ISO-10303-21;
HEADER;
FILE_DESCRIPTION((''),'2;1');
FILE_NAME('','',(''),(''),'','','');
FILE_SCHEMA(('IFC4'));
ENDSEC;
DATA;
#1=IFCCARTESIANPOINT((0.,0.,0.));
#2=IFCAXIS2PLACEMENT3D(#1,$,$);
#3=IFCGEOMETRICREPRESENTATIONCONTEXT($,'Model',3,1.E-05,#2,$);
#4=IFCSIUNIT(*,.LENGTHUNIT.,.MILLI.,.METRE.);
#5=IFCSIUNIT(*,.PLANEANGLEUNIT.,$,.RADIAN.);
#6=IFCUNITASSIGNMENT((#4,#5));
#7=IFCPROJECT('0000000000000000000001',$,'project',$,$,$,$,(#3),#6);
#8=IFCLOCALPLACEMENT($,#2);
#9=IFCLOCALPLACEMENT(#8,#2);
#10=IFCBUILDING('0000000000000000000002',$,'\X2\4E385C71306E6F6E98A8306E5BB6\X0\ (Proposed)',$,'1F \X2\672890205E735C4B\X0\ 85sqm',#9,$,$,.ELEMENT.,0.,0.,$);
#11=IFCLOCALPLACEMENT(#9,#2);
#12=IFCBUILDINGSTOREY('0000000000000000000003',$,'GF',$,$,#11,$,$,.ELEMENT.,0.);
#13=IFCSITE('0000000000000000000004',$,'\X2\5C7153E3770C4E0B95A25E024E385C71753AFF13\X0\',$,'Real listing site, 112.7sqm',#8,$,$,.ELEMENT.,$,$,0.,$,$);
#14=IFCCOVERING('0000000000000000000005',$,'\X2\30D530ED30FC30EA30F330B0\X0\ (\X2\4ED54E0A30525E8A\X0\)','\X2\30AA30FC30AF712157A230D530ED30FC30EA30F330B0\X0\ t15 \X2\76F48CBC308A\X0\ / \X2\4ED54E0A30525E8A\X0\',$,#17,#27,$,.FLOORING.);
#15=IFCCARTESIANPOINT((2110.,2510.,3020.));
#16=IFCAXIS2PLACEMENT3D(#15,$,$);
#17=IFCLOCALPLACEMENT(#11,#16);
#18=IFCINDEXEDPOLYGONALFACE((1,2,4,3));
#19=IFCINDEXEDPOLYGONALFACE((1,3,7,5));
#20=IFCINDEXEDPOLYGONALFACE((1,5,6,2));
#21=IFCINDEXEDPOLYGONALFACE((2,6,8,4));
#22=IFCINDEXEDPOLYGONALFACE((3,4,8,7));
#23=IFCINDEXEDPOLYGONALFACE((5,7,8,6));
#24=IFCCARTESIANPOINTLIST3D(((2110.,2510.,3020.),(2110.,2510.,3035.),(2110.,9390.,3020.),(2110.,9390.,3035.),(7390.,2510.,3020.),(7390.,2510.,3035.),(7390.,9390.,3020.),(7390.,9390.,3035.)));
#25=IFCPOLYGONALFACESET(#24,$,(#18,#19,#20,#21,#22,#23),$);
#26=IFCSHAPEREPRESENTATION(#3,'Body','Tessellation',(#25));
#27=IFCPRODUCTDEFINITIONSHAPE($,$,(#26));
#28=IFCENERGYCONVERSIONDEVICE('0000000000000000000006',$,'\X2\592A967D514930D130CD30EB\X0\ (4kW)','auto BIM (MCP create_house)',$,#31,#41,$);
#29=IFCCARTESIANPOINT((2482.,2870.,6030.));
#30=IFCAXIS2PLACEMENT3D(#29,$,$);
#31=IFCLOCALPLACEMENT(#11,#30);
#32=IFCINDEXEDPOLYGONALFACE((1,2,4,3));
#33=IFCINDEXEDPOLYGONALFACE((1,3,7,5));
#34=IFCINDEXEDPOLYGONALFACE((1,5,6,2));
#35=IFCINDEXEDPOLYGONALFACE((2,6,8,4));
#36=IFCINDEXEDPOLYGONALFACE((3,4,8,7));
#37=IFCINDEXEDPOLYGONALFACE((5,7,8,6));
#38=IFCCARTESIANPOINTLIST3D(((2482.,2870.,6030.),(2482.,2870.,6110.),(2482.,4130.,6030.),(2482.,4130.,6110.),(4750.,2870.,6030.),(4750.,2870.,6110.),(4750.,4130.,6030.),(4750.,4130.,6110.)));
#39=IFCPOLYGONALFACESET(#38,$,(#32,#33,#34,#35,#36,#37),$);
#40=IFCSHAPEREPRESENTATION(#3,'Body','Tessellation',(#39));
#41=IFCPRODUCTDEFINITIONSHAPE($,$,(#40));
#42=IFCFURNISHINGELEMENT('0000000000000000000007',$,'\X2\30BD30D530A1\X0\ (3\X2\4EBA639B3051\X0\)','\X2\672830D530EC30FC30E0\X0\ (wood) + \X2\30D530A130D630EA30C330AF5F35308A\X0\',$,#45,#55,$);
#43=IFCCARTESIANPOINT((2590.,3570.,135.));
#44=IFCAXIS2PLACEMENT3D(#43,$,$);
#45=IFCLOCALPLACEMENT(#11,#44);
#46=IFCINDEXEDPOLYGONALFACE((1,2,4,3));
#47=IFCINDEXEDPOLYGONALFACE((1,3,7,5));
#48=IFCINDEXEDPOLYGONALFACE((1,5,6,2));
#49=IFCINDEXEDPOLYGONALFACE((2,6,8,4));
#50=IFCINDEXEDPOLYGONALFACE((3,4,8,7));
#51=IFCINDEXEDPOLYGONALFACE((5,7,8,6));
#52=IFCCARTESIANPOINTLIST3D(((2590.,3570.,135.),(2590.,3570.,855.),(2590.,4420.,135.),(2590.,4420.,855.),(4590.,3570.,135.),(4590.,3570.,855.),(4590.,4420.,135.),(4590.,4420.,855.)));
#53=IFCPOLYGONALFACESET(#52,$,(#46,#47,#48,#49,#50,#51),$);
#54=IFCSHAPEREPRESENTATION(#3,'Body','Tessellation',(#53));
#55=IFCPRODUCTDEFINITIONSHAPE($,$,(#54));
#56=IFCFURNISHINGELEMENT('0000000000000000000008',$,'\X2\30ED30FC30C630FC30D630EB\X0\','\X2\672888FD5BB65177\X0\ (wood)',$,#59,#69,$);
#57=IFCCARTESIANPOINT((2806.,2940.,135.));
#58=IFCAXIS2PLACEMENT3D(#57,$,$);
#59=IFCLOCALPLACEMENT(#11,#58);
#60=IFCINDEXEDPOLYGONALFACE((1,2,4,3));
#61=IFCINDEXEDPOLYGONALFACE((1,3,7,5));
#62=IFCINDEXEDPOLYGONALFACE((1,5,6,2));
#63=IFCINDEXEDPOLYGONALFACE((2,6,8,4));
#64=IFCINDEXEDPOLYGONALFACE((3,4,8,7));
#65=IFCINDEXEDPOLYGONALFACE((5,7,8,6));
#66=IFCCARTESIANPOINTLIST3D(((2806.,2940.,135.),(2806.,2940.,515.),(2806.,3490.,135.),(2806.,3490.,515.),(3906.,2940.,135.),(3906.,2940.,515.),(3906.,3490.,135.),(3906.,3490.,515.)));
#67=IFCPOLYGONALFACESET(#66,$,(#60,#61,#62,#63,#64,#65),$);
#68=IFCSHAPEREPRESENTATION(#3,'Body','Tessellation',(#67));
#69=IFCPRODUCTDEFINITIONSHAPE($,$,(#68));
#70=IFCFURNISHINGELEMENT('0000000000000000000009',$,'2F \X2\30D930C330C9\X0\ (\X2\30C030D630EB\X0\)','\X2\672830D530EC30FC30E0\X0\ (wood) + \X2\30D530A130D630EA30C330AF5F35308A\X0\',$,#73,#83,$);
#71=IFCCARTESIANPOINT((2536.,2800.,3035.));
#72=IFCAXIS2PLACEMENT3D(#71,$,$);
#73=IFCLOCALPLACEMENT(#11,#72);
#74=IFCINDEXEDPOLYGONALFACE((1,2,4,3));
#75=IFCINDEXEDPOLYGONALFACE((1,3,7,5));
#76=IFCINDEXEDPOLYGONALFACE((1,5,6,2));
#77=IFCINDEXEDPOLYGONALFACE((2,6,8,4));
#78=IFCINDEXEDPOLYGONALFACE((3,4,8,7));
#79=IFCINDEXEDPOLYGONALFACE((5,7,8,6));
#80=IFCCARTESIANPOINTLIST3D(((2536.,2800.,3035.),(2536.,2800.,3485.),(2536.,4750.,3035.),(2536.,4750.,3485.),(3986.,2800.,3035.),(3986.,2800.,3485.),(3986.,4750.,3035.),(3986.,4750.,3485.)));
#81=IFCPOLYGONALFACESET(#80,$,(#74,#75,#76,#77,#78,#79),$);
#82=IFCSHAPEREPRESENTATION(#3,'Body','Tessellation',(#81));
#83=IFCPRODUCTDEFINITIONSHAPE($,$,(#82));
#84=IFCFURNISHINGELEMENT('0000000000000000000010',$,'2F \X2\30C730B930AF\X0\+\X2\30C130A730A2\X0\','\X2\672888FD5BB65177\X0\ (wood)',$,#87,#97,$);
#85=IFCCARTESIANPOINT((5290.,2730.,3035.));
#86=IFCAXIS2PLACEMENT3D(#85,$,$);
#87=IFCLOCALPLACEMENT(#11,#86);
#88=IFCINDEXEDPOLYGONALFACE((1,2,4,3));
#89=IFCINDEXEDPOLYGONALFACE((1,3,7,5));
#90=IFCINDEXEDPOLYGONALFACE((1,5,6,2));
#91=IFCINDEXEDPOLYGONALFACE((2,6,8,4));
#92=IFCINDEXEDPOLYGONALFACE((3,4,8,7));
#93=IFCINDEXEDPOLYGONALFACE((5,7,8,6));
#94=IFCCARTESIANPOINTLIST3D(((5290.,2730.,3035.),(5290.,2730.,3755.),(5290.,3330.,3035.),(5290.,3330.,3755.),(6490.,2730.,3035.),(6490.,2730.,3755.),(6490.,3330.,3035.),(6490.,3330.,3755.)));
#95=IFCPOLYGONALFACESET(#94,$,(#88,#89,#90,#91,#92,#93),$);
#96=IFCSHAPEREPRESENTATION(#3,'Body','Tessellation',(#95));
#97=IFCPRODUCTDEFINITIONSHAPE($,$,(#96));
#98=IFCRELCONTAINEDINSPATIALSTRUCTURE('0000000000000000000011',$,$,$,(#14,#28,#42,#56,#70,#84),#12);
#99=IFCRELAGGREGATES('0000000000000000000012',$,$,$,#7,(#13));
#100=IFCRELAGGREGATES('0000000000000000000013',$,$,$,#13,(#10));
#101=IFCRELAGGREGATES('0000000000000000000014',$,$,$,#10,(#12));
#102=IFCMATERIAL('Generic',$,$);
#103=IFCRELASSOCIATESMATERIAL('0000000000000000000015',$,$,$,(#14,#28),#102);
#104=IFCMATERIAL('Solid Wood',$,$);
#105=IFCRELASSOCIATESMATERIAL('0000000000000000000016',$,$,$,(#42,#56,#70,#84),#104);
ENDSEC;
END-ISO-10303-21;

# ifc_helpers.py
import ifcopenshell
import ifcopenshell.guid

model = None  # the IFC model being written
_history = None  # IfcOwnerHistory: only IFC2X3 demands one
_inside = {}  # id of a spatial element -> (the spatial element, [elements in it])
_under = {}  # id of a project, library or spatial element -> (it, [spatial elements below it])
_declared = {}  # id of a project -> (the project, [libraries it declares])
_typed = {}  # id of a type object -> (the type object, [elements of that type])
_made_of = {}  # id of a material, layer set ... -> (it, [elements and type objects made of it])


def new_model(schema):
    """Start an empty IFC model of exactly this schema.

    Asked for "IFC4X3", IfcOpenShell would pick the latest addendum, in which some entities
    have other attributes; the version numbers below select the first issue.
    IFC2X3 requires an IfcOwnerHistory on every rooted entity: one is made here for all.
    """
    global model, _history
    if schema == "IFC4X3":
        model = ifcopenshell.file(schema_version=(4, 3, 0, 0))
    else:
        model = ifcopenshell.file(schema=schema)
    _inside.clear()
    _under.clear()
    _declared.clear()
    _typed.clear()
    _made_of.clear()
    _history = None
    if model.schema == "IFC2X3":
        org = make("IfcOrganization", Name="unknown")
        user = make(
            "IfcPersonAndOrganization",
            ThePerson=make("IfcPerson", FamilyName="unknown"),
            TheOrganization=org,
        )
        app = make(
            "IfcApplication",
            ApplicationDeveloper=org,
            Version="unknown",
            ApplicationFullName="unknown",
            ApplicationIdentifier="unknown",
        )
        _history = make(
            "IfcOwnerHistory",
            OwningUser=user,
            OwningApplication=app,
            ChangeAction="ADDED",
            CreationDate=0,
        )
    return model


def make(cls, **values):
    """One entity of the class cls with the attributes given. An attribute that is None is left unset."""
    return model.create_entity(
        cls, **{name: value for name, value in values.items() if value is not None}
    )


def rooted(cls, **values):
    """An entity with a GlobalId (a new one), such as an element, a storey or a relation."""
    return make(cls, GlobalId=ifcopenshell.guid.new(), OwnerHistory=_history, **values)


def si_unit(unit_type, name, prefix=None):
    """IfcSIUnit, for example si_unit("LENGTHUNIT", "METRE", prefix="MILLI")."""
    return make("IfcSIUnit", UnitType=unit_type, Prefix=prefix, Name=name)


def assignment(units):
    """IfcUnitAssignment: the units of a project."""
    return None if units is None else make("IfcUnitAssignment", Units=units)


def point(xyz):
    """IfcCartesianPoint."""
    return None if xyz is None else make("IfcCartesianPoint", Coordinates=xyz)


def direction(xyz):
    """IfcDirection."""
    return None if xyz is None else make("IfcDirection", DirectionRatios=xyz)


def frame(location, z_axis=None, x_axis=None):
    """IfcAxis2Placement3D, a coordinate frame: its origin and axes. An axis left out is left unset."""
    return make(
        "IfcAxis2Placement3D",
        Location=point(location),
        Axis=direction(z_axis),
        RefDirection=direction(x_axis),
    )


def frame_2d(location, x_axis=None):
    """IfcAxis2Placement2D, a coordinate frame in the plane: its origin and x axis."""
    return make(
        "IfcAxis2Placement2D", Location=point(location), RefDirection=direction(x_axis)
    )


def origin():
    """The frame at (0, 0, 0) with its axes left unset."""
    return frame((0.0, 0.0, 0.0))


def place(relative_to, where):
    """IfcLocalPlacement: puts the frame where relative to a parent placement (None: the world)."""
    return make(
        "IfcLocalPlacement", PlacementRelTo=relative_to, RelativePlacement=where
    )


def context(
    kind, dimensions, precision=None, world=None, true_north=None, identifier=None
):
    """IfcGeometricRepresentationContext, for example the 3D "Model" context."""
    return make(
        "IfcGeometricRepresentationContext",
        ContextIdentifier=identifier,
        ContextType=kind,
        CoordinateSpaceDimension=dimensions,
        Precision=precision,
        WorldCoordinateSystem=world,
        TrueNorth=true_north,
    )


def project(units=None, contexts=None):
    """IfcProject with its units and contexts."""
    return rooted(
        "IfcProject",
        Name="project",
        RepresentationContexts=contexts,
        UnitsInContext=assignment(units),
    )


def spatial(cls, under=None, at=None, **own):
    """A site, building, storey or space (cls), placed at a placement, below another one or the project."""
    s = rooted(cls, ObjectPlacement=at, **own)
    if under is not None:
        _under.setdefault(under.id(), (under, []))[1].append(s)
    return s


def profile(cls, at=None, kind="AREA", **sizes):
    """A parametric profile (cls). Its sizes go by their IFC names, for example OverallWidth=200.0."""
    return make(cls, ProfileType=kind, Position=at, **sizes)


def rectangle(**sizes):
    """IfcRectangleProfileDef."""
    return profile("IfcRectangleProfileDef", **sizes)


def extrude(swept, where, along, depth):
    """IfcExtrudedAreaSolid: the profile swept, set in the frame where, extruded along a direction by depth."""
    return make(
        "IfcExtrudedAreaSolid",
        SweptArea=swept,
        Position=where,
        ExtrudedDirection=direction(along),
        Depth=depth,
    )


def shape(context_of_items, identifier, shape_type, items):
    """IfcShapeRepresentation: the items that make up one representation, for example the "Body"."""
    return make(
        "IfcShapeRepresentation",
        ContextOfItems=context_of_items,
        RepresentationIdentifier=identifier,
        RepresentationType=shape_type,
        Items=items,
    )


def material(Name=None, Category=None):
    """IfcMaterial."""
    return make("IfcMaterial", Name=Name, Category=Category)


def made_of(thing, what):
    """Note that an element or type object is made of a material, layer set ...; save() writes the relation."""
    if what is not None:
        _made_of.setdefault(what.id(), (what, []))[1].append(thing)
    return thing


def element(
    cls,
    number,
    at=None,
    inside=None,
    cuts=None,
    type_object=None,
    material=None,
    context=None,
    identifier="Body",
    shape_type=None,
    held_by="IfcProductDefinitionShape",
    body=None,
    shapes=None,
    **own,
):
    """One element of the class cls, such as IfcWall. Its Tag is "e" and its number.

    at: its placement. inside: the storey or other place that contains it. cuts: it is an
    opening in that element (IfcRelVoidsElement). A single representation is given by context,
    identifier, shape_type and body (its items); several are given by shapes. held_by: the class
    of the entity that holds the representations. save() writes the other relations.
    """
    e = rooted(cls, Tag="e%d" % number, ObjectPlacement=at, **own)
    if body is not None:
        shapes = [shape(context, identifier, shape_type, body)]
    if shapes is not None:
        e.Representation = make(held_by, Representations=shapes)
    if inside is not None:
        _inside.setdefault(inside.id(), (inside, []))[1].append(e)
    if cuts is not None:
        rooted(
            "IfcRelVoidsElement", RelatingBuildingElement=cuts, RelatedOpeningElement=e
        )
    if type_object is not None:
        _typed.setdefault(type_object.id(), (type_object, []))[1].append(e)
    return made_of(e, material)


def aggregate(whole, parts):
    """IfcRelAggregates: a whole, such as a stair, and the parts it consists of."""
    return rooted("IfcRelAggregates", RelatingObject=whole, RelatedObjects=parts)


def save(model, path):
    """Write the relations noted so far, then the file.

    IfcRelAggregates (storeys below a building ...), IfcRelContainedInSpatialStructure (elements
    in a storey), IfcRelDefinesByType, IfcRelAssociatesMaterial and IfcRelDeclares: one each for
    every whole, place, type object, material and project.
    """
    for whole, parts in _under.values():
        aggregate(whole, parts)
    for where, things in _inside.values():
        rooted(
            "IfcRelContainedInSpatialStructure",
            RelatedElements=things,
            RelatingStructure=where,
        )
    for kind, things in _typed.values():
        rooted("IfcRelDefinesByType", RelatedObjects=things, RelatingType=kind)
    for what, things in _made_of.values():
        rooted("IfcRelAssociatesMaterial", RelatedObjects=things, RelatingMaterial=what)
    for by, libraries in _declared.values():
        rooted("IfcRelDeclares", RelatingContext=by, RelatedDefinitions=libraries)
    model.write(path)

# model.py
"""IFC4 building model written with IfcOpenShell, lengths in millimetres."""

from ifc_helpers import new_model, si_unit, frame, frame_2d, origin, place, context, project, spatial, rectangle, extrude, material, element, save


model = new_model("IFC4")

# Units and contexts
model_context = context("Model", 3, precision=1e-05, world=origin())
ifc_project = project(units=[si_unit("LENGTHUNIT", "METRE", prefix="MILLI"), si_unit("PLANEANGLEUNIT", "RADIAN")], contexts=[model_context])

# Site, building, storey
site_placement = place(None, origin())
site = spatial("IfcSite", under=ifc_project, at=site_placement, Name="山口県下関市丸山町３", ObjectType="Real listing site, 112.7sqm", CompositionType="ELEMENT", RefElevation=0.0)
building_placement = place(site_placement, origin())
building = spatial("IfcBuilding", under=site, at=building_placement, Name="丸山の潮風の家 (Proposed)", ObjectType="1F 木造平屋 85sqm", CompositionType="ELEMENT", ElevationOfRefHeight=0.0, ElevationOfTerrain=0.0)
storey_placement = place(building_placement, origin())
storey = spatial("IfcBuildingStorey", under=building, at=storey_placement, Name="GF", CompositionType="ELEMENT", Elevation=0.0)

# Shared definitions
ifc_material_1 = material(Name="Solid Wood")

# Shared definitions
ifc_material_2 = material(Name="Generic")

# Covering
covering_placement = place(storey_placement, frame((2110.0, 2510.0, 3020.0)))
element("IfcCovering", 1, at=covering_placement, inside=storey, material=ifc_material_2, Name="フローリング (仕上げ床)", Description="オーク無垢フローリング t15 直貼り / 仕上げ床", PredefinedType="FLOORING", context=model_context, shape_type="SweptSolid", body=[
    extrude(rectangle(XDim=5280.0, YDim=6880.0, at=frame_2d((2640.0, 3440.0))), frame((2110.0, 2510.0, 3020.0)), (0.0, 0.0, 1.0), 15.0),
])

# Energy conversion device
energy_conversion_device_placement = place(storey_placement, frame((2482.0, 2870.0, 6030.0)))
element("IfcEnergyConversionDevice", 2, at=energy_conversion_device_placement, inside=storey, material=ifc_material_2, Name="太陽光パネル (4kW)", Description="auto BIM (MCP create_house)", context=model_context, shape_type="SweptSolid", body=[
    extrude(rectangle(XDim=2268.0, YDim=1260.0, at=frame_2d((1134.0, 630.0))), frame((2482.0, 2870.0, 6030.0)), (0.0, 0.0, 1.0), 80.0),
])

# Furnishing elements
furnishing_1_placement = place(storey_placement, frame((2590.0, 3570.0, 135.0)))
element("IfcFurnishingElement", 3, at=furnishing_1_placement, inside=storey, material=ifc_material_1, Name="ソファ (3人掛け)", Description="木フレーム (wood) + ファブリック張り", context=model_context, shape_type="SweptSolid", body=[
    extrude(rectangle(XDim=2000.0, YDim=850.0, at=frame_2d((1000.0, 425.0))), frame((2590.0, 3570.0, 135.0)), (0.0, 0.0, 1.0), 720.0),
])
furnishing_2_placement = place(storey_placement, frame((2806.0, 2940.0, 135.0)))
element("IfcFurnishingElement", 4, at=furnishing_2_placement, inside=storey, material=ifc_material_1, Name="ローテーブル", Description="木製家具 (wood)", context=model_context, shape_type="SweptSolid", body=[
    extrude(rectangle(XDim=1100.0, YDim=550.0, at=frame_2d((550.0, 275.0))), frame((2806.0, 2940.0, 135.0)), (0.0, 0.0, 1.0), 380.0),
])
furnishing_3_placement = place(storey_placement, frame((2536.0, 2800.0, 3035.0)))
element("IfcFurnishingElement", 5, at=furnishing_3_placement, inside=storey, material=ifc_material_1, Name="2F ベッド (ダブル)", Description="木フレーム (wood) + ファブリック張り", context=model_context, shape_type="SweptSolid", body=[
    extrude(rectangle(XDim=1450.0, YDim=1950.0, at=frame_2d((725.0, 975.0))), frame((2536.0, 2800.0, 3035.0)), (0.0, 0.0, 1.0), 450.0),
])
furnishing_4_placement = place(storey_placement, frame((5290.0, 2730.0, 3035.0)))
element("IfcFurnishingElement", 6, at=furnishing_4_placement, inside=storey, material=ifc_material_1, Name="2F デスク+チェア", Description="木製家具 (wood)", context=model_context, shape_type="SweptSolid", body=[
    extrude(rectangle(XDim=1200.0, YDim=600.0, at=frame_2d((600.0, 300.0))), frame((5290.0, 2730.0, 3035.0)), (0.0, 0.0, 1.0), 720.0),
])

save(model, "model.ifc")
